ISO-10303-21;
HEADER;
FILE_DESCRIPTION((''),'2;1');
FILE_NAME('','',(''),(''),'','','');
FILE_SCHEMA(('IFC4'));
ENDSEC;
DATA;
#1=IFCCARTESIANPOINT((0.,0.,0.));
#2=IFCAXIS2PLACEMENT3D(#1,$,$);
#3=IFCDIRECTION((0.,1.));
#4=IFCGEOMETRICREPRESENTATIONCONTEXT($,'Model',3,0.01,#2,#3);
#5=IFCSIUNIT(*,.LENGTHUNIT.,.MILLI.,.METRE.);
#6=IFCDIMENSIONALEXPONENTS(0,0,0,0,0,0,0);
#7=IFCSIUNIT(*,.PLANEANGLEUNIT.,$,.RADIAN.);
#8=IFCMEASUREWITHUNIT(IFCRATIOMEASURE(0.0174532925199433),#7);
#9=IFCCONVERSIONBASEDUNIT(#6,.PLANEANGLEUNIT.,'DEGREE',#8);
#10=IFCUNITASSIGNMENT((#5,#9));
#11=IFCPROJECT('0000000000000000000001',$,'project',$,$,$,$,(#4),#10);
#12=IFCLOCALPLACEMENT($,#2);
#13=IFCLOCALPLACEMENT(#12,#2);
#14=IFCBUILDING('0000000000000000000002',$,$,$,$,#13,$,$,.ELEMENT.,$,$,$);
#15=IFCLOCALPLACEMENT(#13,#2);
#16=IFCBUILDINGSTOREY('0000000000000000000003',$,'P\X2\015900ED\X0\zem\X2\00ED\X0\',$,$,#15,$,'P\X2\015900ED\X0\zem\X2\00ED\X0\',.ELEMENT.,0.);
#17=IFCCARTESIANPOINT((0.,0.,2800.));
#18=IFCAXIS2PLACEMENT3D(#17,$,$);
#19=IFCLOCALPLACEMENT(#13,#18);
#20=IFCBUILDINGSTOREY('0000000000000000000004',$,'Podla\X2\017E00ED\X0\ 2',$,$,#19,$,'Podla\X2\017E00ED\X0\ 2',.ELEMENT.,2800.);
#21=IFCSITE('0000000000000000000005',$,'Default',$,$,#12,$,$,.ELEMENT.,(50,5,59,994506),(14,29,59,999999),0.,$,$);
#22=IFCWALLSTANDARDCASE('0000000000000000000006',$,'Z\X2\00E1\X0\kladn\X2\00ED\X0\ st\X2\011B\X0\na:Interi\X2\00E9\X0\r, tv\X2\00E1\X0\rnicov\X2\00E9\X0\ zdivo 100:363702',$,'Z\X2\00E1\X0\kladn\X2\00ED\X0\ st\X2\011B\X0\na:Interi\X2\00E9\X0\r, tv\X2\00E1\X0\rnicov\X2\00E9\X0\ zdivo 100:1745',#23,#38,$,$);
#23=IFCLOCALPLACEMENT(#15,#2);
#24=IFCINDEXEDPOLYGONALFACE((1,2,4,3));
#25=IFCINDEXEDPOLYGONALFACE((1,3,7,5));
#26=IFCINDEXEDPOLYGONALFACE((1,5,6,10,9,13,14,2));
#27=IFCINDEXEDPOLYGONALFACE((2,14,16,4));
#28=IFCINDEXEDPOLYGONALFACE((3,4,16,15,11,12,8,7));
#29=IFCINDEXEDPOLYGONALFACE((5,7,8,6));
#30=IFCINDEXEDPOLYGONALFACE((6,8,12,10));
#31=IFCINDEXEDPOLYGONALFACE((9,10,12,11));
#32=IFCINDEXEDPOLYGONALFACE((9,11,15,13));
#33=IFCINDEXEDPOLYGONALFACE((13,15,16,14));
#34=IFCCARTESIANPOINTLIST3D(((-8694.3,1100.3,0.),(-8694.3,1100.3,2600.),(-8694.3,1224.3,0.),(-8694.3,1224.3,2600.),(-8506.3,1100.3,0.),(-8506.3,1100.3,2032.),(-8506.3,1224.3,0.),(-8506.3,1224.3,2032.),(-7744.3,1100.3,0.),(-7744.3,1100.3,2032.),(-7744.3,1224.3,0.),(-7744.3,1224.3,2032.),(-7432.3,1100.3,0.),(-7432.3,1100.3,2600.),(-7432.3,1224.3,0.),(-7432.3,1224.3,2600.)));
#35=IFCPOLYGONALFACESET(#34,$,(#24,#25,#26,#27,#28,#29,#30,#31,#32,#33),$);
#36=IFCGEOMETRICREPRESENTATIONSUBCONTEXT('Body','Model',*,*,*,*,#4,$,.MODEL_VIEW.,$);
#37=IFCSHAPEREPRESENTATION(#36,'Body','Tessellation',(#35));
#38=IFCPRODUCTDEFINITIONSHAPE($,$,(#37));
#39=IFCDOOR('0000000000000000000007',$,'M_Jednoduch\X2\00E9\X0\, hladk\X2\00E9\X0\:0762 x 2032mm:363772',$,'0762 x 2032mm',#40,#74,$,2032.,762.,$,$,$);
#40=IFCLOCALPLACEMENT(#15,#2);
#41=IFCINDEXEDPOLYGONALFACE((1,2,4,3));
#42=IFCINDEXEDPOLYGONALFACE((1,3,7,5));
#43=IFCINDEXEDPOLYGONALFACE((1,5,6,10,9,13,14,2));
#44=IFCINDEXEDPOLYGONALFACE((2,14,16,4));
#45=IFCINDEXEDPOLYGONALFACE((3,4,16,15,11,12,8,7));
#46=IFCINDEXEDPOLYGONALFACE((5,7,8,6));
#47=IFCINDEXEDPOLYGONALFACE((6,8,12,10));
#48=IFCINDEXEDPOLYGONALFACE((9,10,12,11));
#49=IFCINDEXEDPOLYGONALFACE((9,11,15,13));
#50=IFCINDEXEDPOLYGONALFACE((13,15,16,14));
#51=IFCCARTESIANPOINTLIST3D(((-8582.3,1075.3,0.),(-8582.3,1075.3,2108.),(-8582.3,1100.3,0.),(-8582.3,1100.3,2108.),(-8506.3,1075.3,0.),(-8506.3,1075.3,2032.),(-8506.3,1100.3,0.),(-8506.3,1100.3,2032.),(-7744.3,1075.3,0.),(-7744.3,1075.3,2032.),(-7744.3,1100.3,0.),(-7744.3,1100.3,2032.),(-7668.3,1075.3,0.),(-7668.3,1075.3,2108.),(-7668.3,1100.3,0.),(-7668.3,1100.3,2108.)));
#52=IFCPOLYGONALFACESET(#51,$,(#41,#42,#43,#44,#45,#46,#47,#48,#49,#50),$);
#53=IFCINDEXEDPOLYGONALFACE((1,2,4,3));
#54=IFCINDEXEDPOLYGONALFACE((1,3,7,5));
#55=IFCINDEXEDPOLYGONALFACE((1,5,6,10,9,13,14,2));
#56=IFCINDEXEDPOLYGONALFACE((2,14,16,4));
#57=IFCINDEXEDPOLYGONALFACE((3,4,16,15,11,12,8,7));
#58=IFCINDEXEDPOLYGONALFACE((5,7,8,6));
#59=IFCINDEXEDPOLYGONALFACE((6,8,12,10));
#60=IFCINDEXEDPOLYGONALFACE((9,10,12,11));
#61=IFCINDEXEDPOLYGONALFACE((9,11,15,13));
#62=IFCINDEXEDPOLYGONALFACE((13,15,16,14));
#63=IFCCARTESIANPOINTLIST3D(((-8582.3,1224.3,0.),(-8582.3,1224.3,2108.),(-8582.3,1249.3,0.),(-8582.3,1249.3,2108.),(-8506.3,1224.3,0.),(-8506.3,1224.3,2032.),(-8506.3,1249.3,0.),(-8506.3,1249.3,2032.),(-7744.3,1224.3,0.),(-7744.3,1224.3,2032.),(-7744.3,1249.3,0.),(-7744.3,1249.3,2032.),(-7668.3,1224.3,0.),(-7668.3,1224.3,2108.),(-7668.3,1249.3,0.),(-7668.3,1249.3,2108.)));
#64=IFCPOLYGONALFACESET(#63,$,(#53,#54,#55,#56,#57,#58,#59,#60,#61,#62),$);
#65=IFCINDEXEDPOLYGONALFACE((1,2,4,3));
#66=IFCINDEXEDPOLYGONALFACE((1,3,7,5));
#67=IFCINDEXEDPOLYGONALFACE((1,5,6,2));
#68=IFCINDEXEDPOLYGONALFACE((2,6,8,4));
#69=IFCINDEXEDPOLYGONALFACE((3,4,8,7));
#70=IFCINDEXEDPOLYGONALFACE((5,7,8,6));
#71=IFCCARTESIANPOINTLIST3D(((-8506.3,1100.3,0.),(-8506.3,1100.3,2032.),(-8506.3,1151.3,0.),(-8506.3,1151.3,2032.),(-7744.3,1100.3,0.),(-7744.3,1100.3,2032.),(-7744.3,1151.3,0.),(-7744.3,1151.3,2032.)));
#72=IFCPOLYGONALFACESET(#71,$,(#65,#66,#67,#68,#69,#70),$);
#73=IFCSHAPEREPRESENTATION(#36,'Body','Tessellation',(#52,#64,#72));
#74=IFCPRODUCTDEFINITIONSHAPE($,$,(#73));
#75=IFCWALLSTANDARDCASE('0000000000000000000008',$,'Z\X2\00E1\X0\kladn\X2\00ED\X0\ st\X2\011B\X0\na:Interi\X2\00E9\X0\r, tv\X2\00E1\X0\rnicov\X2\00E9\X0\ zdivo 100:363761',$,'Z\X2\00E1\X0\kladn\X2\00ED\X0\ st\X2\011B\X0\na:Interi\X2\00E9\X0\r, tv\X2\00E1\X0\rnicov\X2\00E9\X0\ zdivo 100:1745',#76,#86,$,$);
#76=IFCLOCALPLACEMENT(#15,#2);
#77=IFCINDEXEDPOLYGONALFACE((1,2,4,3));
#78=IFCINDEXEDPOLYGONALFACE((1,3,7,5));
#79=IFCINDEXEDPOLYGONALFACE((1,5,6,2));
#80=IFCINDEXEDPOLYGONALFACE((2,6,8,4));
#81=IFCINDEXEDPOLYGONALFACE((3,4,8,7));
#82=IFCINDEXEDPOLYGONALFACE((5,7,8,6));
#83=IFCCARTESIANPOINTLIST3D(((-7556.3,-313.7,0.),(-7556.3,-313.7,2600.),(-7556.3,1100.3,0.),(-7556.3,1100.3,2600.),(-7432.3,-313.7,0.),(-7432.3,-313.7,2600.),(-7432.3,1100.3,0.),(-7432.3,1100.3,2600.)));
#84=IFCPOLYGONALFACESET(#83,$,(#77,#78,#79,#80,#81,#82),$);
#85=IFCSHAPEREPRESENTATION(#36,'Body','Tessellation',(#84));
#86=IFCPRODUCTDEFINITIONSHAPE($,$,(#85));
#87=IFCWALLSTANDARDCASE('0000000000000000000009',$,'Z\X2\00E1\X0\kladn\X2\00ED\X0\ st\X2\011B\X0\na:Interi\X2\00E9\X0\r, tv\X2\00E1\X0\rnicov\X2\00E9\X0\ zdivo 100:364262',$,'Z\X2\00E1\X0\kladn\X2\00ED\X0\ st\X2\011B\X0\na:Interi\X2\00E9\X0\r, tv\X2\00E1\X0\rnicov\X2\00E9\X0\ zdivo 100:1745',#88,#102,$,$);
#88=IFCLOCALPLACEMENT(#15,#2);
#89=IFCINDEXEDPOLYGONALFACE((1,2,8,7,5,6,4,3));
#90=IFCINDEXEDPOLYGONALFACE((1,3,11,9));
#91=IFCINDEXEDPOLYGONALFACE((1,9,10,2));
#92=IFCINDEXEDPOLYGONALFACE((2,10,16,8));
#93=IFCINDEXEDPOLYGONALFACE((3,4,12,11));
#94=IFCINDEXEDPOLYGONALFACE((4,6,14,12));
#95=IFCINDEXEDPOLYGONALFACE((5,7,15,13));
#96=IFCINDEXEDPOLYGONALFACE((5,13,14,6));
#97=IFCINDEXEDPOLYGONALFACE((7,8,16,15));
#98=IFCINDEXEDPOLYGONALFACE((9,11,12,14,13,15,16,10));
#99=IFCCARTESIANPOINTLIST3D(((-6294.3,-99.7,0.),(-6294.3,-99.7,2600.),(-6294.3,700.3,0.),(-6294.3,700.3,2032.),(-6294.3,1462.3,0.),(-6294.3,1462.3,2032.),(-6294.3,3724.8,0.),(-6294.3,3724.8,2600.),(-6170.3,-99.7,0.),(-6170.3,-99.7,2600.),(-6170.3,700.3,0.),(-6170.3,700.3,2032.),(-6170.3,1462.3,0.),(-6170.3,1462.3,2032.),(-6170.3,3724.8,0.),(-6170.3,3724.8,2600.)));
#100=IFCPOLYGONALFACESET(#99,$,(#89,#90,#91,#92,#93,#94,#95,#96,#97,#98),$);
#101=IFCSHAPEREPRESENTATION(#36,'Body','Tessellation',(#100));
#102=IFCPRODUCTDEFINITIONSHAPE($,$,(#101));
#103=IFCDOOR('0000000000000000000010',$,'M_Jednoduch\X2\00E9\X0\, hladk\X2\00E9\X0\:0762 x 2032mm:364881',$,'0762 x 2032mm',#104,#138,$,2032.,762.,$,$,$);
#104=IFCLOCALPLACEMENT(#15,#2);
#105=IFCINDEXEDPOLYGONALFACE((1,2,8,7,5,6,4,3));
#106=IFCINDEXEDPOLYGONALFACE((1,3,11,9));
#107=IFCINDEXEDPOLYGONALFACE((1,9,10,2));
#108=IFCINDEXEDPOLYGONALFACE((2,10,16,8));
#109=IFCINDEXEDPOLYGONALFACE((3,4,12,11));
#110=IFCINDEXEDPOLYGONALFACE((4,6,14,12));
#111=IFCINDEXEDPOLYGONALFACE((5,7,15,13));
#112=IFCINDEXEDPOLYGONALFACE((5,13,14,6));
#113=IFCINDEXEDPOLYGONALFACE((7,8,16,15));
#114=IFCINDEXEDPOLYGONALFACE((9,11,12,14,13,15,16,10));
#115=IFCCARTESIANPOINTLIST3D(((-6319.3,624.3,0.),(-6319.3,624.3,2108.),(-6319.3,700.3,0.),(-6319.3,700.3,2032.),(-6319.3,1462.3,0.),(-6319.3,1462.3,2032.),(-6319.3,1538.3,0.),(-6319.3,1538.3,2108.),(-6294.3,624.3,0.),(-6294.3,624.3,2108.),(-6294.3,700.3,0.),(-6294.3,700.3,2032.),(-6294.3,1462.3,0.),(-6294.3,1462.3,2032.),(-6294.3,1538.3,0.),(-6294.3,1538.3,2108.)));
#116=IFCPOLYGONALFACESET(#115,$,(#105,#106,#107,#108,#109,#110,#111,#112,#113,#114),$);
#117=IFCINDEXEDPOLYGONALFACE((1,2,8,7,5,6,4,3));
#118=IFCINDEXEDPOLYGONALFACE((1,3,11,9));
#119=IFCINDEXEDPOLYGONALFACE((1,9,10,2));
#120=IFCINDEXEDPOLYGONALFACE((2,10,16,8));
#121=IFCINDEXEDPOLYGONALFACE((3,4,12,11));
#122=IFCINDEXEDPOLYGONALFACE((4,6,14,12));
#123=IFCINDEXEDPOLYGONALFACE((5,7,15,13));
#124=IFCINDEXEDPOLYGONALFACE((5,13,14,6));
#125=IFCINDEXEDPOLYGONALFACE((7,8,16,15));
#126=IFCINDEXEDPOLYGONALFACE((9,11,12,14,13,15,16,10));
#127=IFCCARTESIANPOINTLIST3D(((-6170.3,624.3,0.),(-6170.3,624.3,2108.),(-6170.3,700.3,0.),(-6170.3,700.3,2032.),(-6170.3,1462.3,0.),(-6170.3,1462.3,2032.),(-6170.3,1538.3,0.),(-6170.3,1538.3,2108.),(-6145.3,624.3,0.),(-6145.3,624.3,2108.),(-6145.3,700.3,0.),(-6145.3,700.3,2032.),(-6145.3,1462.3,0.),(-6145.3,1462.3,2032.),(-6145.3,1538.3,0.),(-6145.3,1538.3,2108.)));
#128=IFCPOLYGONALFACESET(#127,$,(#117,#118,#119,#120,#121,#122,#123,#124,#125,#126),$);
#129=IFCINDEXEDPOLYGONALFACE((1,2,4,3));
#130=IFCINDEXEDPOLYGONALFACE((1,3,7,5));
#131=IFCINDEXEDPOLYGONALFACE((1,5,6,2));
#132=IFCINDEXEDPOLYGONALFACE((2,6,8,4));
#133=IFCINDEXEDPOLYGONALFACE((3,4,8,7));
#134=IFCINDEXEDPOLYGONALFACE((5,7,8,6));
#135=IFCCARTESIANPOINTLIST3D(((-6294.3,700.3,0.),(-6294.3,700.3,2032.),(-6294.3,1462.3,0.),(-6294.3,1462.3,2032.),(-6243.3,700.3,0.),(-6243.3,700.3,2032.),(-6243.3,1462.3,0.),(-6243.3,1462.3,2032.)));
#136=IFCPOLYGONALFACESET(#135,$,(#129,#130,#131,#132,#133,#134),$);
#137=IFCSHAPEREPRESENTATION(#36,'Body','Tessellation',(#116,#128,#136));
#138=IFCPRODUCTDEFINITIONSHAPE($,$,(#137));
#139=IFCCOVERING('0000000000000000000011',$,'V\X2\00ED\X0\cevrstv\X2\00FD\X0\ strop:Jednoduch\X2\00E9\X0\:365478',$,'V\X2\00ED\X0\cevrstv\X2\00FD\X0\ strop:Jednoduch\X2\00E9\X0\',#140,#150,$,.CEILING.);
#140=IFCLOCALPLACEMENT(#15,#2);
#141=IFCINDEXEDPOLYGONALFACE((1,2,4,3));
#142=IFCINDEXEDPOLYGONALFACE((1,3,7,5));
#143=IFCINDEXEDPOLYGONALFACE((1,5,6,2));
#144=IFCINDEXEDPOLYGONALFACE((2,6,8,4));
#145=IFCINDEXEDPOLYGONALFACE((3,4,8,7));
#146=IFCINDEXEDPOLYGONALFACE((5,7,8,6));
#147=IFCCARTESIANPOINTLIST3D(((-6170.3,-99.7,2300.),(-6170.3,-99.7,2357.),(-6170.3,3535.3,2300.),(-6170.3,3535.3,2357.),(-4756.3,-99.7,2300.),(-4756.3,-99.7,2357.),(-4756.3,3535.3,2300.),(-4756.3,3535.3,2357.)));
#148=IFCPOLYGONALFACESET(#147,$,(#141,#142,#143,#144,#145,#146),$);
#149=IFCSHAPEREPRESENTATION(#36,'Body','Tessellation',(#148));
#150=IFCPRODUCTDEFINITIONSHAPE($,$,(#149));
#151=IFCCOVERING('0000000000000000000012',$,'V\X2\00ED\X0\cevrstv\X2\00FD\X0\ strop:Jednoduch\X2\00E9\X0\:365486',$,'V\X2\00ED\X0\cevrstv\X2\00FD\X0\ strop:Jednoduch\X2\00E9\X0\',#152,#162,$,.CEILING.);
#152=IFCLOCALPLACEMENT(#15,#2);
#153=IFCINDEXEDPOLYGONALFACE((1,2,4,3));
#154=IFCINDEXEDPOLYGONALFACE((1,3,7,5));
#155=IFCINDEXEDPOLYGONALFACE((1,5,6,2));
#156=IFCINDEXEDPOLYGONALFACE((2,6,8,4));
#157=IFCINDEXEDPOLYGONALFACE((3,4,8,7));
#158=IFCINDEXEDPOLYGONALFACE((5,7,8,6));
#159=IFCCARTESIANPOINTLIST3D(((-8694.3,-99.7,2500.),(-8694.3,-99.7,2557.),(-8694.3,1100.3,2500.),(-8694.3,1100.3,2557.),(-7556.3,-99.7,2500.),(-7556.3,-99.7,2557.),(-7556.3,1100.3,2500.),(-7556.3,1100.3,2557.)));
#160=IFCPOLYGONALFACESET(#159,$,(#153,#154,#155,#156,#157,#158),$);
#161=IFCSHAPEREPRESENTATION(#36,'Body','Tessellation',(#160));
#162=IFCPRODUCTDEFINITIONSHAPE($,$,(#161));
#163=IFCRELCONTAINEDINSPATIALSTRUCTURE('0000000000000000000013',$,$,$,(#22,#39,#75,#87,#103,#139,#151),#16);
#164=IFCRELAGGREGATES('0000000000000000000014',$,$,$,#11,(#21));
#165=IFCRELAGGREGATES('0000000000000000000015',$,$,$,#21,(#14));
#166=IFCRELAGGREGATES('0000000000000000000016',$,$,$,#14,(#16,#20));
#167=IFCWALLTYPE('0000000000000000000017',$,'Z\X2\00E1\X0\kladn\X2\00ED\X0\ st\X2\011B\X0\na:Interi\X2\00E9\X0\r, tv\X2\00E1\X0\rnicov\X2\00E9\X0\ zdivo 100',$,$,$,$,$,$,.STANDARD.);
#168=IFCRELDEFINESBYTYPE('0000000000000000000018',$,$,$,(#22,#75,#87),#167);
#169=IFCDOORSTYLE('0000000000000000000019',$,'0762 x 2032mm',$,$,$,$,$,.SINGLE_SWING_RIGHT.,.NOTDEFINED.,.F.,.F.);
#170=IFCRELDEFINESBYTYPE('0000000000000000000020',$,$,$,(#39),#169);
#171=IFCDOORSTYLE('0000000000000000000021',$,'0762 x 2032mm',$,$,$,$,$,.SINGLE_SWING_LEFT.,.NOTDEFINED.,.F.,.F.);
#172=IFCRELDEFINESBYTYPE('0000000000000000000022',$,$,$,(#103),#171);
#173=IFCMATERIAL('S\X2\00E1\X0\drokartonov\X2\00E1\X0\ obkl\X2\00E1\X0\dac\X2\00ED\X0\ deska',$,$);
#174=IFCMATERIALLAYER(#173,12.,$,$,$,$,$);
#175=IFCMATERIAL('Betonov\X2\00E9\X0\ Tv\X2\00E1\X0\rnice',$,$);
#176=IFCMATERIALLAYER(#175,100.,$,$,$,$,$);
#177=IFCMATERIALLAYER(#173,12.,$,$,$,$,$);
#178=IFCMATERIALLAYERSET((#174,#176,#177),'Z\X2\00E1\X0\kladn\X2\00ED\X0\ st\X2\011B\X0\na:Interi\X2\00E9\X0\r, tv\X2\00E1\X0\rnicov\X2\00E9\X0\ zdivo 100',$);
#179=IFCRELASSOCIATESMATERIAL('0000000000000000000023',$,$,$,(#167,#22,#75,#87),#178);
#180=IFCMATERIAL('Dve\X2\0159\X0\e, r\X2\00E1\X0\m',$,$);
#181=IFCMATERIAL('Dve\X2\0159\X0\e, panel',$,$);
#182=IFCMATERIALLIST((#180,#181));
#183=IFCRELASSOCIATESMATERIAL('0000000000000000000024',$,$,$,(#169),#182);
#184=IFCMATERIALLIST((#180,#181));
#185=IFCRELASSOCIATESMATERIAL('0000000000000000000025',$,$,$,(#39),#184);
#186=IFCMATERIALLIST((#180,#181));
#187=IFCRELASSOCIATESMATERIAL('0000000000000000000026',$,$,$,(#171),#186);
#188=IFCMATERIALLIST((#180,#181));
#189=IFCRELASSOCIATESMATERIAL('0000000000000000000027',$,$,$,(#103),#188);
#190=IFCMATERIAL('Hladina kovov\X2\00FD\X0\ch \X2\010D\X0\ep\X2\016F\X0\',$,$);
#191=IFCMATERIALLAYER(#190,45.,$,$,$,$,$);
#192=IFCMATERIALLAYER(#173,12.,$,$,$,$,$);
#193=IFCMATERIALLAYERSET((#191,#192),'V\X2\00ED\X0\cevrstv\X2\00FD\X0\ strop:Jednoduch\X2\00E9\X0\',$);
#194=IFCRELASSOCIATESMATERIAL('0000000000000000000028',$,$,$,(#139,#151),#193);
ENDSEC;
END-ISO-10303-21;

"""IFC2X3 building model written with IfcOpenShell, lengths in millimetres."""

from ifc_helpers import new_model, entity, si_unit, converted_unit, direction, frame, frame_2d, origin, origin_2d_with_axis, place, context, subcontext, project, spatial, polyline, rectangle, outline, extrude, clip, bounded_halfspace, source, transform, mapped, material, material_list, layer, layer_set, layer_usage, type_object, type_shapes, element, fill, save


model = new_model("IFC2X3")

# Units and contexts
model_context = context("Model", 3, precision=0.01, world=origin(), true_north=direction((0.0, 1.0)))
body_context = subcontext(model_context, "Body", "Model", "MODEL_VIEW")
ifc_project = project(units=[si_unit("LENGTHUNIT", "METRE", prefix="MILLI"), converted_unit("PLANEANGLEUNIT", "DEGREE", entity("IfcRatioMeasure", 0.0174532925199433), si_unit("PLANEANGLEUNIT", "RADIAN"), dimensions=[0, 0, 0, 0, 0, 0, 0])], contexts=[model_context])

# Site, building, storey
site_placement = place(None, origin())
site = spatial("IfcSite", under=ifc_project, at=site_placement, Name="Default", CompositionType="ELEMENT", RefLatitude=(50, 5, 59, 994506), RefLongitude=(14, 29, 59, 999999), RefElevation=0.0)
building_placement = place(site_placement, origin())
building = spatial("IfcBuilding", under=site, at=building_placement, CompositionType="ELEMENT")
storey_1_placement = place(building_placement, origin())
storey_1 = spatial("IfcBuildingStorey", under=building, at=storey_1_placement, Name="Přízemí", LongName="Přízemí", CompositionType="ELEMENT", Elevation=0.0)

# Shared definitions
ifc_material_1 = material(Name="Betonové Tvárnice")
ifc_material_2 = material(Name="Sádrokartonová obkládací deska")

# Shared definitions
storey_2_placement = place(building_placement, frame((0.0, 0.0, 2800.0)))
storey_2 = spatial("IfcBuildingStorey", under=building, at=storey_2_placement, Name="Podlaží 2", LongName="Podlaží 2", CompositionType="ELEMENT", Elevation=2800.0)

# Shared definitions
ifc_material_3 = material(Name="Dveře, rám")
ifc_material_4 = material(Name="Dveře, panel")

# Shared definitions
ifc_layer_1 = layer(ifc_material_2, 12.0)
ifc_layer_2 = layer(ifc_material_1, 100.0)
ifc_layer_3 = layer(ifc_material_2, 12.0)
ifc_layer_set_1 = layer_set([ifc_layer_1, ifc_layer_2, ifc_layer_3], Name="Základní stěna:Interiér, tvárnicové zdivo 100")
wall_type_1 = type_object("IfcWallType", Name="Základní stěna:Interiér, tvárnicové zdivo 100", PredefinedType="STANDARD", material=ifc_layer_set_1)

# Wall, opening, door
ifc_layer_usage_1 = layer_usage(ifc_layer_set_1, "AXIS2", "NEGATIVE", 62.0)
wall_1_placement = place(storey_1_placement, frame((-8694.3, 1162.3, 0.0)))
wall_1 = element("IfcWallStandardCase", 1, at=wall_1_placement, inside=storey_1, type_object=wall_type_1, material=ifc_layer_usage_1, Name="Základní stěna:Interiér, tvárnicové zdivo 100:363702", ObjectType="Základní stěna:Interiér, tvárnicové zdivo 100:1745", context=body_context, shape_type="Clipping", body=[
    clip(extrude(rectangle(XDim=1262.0, YDim=124.0, at=frame_2d((631.0, 0.0), x_axis=(-1.0, 0.0))), origin(), (0.0, 0.0, 1.0), 2600.0), bounded_halfspace(frame((0.0, -62.0, 2600.0), z_axis=(0.0, 0.0, -1.0), x_axis=(1.0, 0.0, 0.0)), True, frame((0.0, -62.0, 2600.0)), polyline([(0.0, 0.0), (1138.0, 0.0), (1262.0, 0.0), (1262.0, 124.0), (0.0, 124.0), (0.0, 0.0)]))),
])
opening_1_placement = place(wall_1_placement, frame((950.0, 62.0, 0.0)))
opening_1 = element("IfcOpeningElement", 2, at=opening_1_placement, cuts=wall_1, ObjectType="Opening", context=body_context, shape_type="SweptSolid", body=[
    extrude(rectangle(XDim=762.0, YDim=2032.0, at=frame_2d((1016.0, 381.0), x_axis=(0.0, 1.0))), frame((0.0, 0.0, 0.0), z_axis=(0.0, -1.0, 0.0), x_axis=(0.0, 0.0, 1.0)), (0.0, 0.0, 1.0), 124.0),
])
ifc_material_list_1 = material_list([ifc_material_3, ifc_material_4])
ifc_material_list_2 = material_list([ifc_material_3, ifc_material_4])
door_style_1 = type_object("IfcDoorStyle", Name="0762 x 2032mm", ConstructionType="NOTDEFINED", OperationType="SINGLE_SWING_RIGHT", ParameterTakesPrecedence=False, Sizeable=False, material=ifc_material_list_2)
shared_shape_1 = source(origin(), body_context, "Body", "SweptSolid", [
    extrude(outline(polyline([(-457.0, -1073.0), (457.0, -1073.0), (457.0, 1035.0), (381.0, 1035.0), (381.0, -997.0), (-381.0, -997.0), (-381.0, 1035.0), (-457.0, 1035.0), (-457.0, -1073.0)])), frame((381.0, 124.0, 1035.0), z_axis=(0.0, 1.0, 0.0), x_axis=(1.0, 0.0, 0.0)), (0.0, 0.0, 1.0), 25.0),
    extrude(outline(polyline([(-1073.0, -457.0), (1035.0, -457.0), (1035.0, -381.0), (-997.0, -381.0), (-997.0, 381.0), (1035.0, 381.0), (1035.0, 457.0), (-1073.0, 457.0), (-1073.0, -457.0)])), frame((381.0, -25.0, 1035.0), z_axis=(0.0, 1.0, 0.0), x_axis=(0.0, 0.0, -1.0)), (0.0, 0.0, 1.0), 25.0),
    extrude(rectangle(XDim=51.0, YDim=762.0, at=origin_2d_with_axis()), frame((381.0, 98.5, 0.0), z_axis=(0.0, 0.0, 1.0), x_axis=(0.0, 1.0, 0.0)), (0.0, 0.0, 1.0), 2032.0),
])
type_shapes(door_style_1, [shared_shape_1])
door_1_placement = place(opening_1_placement, frame((0.0, 0.0, 0.0), z_axis=(0.0, 0.0, 1.0), x_axis=(-1.0, 0.0, 0.0)))
door_1 = element("IfcDoor", 3, at=door_1_placement, inside=storey_1, type_object=door_style_1, material=ifc_material_list_1, Name="M_Jednoduché, hladké:0762 x 2032mm:363772", ObjectType="0762 x 2032mm", OverallHeight=2032.0, OverallWidth=762.0, context=body_context, shape_type="MappedRepresentation", body=[
    mapped(shared_shape_1, transform((0.0, 0.0, 0.0), scale=1.0)),
])
fill(opening_1, door_1)

# Wall
ifc_layer_usage_2 = layer_usage(ifc_layer_set_1, "AXIS2", "NEGATIVE", 62.0)
wall_2_placement = place(storey_1_placement, frame((-7494.3, 1100.3, 0.0), z_axis=(0.0, 0.0, 1.0), x_axis=(0.0, -1.0, 0.0)))
element("IfcWallStandardCase", 4, at=wall_2_placement, inside=storey_1, type_object=wall_type_1, material=ifc_layer_usage_2, Name="Základní stěna:Interiér, tvárnicové zdivo 100:363761", ObjectType="Základní stěna:Interiér, tvárnicové zdivo 100:1745", context=body_context, shape_type="Clipping", body=[
    clip(extrude(rectangle(XDim=1414.0, YDim=124.0, at=frame_2d((707.0, 0.0), x_axis=(-1.0, 0.0))), origin(), (0.0, 0.0, 1.0), 2600.0), bounded_halfspace(frame((0.0, -62.0, 2600.0), z_axis=(0.0, 0.0, -1.0), x_axis=(0.0, 1.0, 0.0)), True, frame((0.0, -62.0, 2600.0)), polyline([(0.0, 0.0), (1414.0, 0.0), (1414.0, 124.0), (0.0, 124.0), (0.0, 0.0)]))),
])

# Wall, opening, door
ifc_layer_usage_3 = layer_usage(ifc_layer_set_1, "AXIS2", "NEGATIVE", 62.0)
wall_3_placement = place(storey_1_placement, frame((-6232.3, -99.7, 0.0), z_axis=(0.0, 0.0, 1.0), x_axis=(0.0, 1.0, 0.0)))
wall_3 = element("IfcWallStandardCase", 5, at=wall_3_placement, inside=storey_1, type_object=wall_type_1, material=ifc_layer_usage_3, Name="Základní stěna:Interiér, tvárnicové zdivo 100:364262", ObjectType="Základní stěna:Interiér, tvárnicové zdivo 100:1745", context=body_context, shape_type="Clipping", body=[
    clip(extrude(rectangle(XDim=3824.5, YDim=124.0, at=frame_2d((1912.2, 0.0), x_axis=(-1.0, 0.0))), origin(), (0.0, 0.0, 1.0), 2600.0), bounded_halfspace(frame((0.0, -62.0, 2600.0), z_axis=(0.0, 0.0, -1.0), x_axis=(0.0, -1.0, 0.0)), True, frame((0.0, -62.0, 2600.0)), polyline([(0.0, 0.0), (3647.0, 0.0), (3647.0, 124.0), (0.0, 124.0), (0.0, 0.0)]))),
])
opening_2_placement = place(wall_3_placement, frame((800.0, -62.0, 0.0)))
opening_2 = element("IfcOpeningElement", 6, at=opening_2_placement, cuts=wall_3, ObjectType="Opening", context=body_context, shape_type="SweptSolid", body=[
    extrude(rectangle(XDim=762.0, YDim=2032.0, at=frame_2d((1016.0, 381.0), x_axis=(0.0, -1.0))), frame((0.0, 0.0, 0.0), z_axis=(0.0, 1.0, 0.0), x_axis=(0.0, 0.0, 1.0)), (0.0, 0.0, 1.0), 124.0),
])
ifc_material_list_3 = material_list([ifc_material_3, ifc_material_4])
ifc_material_list_4 = material_list([ifc_material_3, ifc_material_4])
door_style_2 = type_object("IfcDoorStyle", Name="0762 x 2032mm", ConstructionType="NOTDEFINED", OperationType="SINGLE_SWING_LEFT", ParameterTakesPrecedence=False, Sizeable=False, material=ifc_material_list_4)
shared_shape_2 = source(origin(), body_context, "Body", "SweptSolid", [
    extrude(outline(polyline([(-457.0, -1073.0), (457.0, -1073.0), (457.0, 1035.0), (381.0, 1035.0), (381.0, -997.0), (-381.0, -997.0), (-381.0, 1035.0), (-457.0, 1035.0), (-457.0, -1073.0)])), frame((381.0, 149.0, 1035.0), z_axis=(0.0, -1.0, 0.0), x_axis=(-1.0, 0.0, 0.0)), (0.0, 0.0, 1.0), 25.0),
    extrude(outline(polyline([(-1073.0, -457.0), (1035.0, -457.0), (1035.0, -381.0), (-997.0, -381.0), (-997.0, 381.0), (1035.0, 381.0), (1035.0, 457.0), (-1073.0, 457.0), (-1073.0, -457.0)])), frame((381.0, 0.0, 1035.0), z_axis=(0.0, -1.0, 0.0), x_axis=(0.0, 0.0, -1.0)), (0.0, 0.0, 1.0), 25.0),
    extrude(rectangle(XDim=762.0, YDim=51.0, at=frame_2d((0.0, 0.0), x_axis=(1.0, 0.0))), frame((381.0, 98.5, 0.0)), (0.0, 0.0, 1.0), 2032.0),
])
type_shapes(door_style_2, [shared_shape_2])
door_2_placement = place(opening_2_placement, origin())
door_2 = element("IfcDoor", 7, at=door_2_placement, inside=storey_1, type_object=door_style_2, material=ifc_material_list_3, Name="M_Jednoduché, hladké:0762 x 2032mm:364881", ObjectType="0762 x 2032mm", OverallHeight=2032.0, OverallWidth=762.0, context=body_context, shape_type="MappedRepresentation", body=[
    mapped(shared_shape_2, transform((0.0, 0.0, 0.0), scale=1.0)),
])
fill(opening_2, door_2)

# Coverings
ifc_material_5 = material(Name="Hladina kovových čepů")
ifc_layer_4 = layer(ifc_material_5, 45.0)
ifc_layer_5 = layer(ifc_material_2, 12.0)
ifc_layer_set_2 = layer_set([ifc_layer_4, ifc_layer_5], Name="Vícevrstvý strop:Jednoduché")
ifc_layer_usage_4 = layer_usage(ifc_layer_set_2, "AXIS3", "NEGATIVE", 0.0)
covering_1_placement = place(storey_1_placement, origin())
element("IfcCovering", 8, at=covering_1_placement, inside=storey_1, material=ifc_layer_usage_4, Name="Vícevrstvý strop:Jednoduché:365478", ObjectType="Vícevrstvý strop:Jednoduché", PredefinedType="CEILING", context=body_context, shape_type="SweptSolid", body=[
    extrude(rectangle(XDim=3635.0, YDim=1414.0, at=frame_2d((0.0, 0.0), x_axis=(1.0, 0.0))), frame((-5463.3, 1717.8, 2300.0), z_axis=(0.0, 0.0, 1.0), x_axis=(0.0, -1.0, 0.0)), (0.0, 0.0, 1.0), 57.0),
])
ifc_layer_usage_5 = layer_usage(ifc_layer_set_2, "AXIS3", "NEGATIVE", 0.0)
covering_2_placement = place(storey_1_placement, origin())
element("IfcCovering", 9, at=covering_2_placement, inside=storey_1, material=ifc_layer_usage_5, Name="Vícevrstvý strop:Jednoduché:365486", ObjectType="Vícevrstvý strop:Jednoduché", PredefinedType="CEILING", context=body_context, shape_type="SweptSolid", body=[
    extrude(rectangle(XDim=1200.0, YDim=1138.0, at=frame_2d((0.0, 0.0), x_axis=(1.0, 0.0))), frame((-8125.3, 500.3, 2500.0), z_axis=(0.0, 0.0, 1.0), x_axis=(0.0, 1.0, 0.0)), (0.0, 0.0, 1.0), 57.0),
])

save(model, "model.ifc")
